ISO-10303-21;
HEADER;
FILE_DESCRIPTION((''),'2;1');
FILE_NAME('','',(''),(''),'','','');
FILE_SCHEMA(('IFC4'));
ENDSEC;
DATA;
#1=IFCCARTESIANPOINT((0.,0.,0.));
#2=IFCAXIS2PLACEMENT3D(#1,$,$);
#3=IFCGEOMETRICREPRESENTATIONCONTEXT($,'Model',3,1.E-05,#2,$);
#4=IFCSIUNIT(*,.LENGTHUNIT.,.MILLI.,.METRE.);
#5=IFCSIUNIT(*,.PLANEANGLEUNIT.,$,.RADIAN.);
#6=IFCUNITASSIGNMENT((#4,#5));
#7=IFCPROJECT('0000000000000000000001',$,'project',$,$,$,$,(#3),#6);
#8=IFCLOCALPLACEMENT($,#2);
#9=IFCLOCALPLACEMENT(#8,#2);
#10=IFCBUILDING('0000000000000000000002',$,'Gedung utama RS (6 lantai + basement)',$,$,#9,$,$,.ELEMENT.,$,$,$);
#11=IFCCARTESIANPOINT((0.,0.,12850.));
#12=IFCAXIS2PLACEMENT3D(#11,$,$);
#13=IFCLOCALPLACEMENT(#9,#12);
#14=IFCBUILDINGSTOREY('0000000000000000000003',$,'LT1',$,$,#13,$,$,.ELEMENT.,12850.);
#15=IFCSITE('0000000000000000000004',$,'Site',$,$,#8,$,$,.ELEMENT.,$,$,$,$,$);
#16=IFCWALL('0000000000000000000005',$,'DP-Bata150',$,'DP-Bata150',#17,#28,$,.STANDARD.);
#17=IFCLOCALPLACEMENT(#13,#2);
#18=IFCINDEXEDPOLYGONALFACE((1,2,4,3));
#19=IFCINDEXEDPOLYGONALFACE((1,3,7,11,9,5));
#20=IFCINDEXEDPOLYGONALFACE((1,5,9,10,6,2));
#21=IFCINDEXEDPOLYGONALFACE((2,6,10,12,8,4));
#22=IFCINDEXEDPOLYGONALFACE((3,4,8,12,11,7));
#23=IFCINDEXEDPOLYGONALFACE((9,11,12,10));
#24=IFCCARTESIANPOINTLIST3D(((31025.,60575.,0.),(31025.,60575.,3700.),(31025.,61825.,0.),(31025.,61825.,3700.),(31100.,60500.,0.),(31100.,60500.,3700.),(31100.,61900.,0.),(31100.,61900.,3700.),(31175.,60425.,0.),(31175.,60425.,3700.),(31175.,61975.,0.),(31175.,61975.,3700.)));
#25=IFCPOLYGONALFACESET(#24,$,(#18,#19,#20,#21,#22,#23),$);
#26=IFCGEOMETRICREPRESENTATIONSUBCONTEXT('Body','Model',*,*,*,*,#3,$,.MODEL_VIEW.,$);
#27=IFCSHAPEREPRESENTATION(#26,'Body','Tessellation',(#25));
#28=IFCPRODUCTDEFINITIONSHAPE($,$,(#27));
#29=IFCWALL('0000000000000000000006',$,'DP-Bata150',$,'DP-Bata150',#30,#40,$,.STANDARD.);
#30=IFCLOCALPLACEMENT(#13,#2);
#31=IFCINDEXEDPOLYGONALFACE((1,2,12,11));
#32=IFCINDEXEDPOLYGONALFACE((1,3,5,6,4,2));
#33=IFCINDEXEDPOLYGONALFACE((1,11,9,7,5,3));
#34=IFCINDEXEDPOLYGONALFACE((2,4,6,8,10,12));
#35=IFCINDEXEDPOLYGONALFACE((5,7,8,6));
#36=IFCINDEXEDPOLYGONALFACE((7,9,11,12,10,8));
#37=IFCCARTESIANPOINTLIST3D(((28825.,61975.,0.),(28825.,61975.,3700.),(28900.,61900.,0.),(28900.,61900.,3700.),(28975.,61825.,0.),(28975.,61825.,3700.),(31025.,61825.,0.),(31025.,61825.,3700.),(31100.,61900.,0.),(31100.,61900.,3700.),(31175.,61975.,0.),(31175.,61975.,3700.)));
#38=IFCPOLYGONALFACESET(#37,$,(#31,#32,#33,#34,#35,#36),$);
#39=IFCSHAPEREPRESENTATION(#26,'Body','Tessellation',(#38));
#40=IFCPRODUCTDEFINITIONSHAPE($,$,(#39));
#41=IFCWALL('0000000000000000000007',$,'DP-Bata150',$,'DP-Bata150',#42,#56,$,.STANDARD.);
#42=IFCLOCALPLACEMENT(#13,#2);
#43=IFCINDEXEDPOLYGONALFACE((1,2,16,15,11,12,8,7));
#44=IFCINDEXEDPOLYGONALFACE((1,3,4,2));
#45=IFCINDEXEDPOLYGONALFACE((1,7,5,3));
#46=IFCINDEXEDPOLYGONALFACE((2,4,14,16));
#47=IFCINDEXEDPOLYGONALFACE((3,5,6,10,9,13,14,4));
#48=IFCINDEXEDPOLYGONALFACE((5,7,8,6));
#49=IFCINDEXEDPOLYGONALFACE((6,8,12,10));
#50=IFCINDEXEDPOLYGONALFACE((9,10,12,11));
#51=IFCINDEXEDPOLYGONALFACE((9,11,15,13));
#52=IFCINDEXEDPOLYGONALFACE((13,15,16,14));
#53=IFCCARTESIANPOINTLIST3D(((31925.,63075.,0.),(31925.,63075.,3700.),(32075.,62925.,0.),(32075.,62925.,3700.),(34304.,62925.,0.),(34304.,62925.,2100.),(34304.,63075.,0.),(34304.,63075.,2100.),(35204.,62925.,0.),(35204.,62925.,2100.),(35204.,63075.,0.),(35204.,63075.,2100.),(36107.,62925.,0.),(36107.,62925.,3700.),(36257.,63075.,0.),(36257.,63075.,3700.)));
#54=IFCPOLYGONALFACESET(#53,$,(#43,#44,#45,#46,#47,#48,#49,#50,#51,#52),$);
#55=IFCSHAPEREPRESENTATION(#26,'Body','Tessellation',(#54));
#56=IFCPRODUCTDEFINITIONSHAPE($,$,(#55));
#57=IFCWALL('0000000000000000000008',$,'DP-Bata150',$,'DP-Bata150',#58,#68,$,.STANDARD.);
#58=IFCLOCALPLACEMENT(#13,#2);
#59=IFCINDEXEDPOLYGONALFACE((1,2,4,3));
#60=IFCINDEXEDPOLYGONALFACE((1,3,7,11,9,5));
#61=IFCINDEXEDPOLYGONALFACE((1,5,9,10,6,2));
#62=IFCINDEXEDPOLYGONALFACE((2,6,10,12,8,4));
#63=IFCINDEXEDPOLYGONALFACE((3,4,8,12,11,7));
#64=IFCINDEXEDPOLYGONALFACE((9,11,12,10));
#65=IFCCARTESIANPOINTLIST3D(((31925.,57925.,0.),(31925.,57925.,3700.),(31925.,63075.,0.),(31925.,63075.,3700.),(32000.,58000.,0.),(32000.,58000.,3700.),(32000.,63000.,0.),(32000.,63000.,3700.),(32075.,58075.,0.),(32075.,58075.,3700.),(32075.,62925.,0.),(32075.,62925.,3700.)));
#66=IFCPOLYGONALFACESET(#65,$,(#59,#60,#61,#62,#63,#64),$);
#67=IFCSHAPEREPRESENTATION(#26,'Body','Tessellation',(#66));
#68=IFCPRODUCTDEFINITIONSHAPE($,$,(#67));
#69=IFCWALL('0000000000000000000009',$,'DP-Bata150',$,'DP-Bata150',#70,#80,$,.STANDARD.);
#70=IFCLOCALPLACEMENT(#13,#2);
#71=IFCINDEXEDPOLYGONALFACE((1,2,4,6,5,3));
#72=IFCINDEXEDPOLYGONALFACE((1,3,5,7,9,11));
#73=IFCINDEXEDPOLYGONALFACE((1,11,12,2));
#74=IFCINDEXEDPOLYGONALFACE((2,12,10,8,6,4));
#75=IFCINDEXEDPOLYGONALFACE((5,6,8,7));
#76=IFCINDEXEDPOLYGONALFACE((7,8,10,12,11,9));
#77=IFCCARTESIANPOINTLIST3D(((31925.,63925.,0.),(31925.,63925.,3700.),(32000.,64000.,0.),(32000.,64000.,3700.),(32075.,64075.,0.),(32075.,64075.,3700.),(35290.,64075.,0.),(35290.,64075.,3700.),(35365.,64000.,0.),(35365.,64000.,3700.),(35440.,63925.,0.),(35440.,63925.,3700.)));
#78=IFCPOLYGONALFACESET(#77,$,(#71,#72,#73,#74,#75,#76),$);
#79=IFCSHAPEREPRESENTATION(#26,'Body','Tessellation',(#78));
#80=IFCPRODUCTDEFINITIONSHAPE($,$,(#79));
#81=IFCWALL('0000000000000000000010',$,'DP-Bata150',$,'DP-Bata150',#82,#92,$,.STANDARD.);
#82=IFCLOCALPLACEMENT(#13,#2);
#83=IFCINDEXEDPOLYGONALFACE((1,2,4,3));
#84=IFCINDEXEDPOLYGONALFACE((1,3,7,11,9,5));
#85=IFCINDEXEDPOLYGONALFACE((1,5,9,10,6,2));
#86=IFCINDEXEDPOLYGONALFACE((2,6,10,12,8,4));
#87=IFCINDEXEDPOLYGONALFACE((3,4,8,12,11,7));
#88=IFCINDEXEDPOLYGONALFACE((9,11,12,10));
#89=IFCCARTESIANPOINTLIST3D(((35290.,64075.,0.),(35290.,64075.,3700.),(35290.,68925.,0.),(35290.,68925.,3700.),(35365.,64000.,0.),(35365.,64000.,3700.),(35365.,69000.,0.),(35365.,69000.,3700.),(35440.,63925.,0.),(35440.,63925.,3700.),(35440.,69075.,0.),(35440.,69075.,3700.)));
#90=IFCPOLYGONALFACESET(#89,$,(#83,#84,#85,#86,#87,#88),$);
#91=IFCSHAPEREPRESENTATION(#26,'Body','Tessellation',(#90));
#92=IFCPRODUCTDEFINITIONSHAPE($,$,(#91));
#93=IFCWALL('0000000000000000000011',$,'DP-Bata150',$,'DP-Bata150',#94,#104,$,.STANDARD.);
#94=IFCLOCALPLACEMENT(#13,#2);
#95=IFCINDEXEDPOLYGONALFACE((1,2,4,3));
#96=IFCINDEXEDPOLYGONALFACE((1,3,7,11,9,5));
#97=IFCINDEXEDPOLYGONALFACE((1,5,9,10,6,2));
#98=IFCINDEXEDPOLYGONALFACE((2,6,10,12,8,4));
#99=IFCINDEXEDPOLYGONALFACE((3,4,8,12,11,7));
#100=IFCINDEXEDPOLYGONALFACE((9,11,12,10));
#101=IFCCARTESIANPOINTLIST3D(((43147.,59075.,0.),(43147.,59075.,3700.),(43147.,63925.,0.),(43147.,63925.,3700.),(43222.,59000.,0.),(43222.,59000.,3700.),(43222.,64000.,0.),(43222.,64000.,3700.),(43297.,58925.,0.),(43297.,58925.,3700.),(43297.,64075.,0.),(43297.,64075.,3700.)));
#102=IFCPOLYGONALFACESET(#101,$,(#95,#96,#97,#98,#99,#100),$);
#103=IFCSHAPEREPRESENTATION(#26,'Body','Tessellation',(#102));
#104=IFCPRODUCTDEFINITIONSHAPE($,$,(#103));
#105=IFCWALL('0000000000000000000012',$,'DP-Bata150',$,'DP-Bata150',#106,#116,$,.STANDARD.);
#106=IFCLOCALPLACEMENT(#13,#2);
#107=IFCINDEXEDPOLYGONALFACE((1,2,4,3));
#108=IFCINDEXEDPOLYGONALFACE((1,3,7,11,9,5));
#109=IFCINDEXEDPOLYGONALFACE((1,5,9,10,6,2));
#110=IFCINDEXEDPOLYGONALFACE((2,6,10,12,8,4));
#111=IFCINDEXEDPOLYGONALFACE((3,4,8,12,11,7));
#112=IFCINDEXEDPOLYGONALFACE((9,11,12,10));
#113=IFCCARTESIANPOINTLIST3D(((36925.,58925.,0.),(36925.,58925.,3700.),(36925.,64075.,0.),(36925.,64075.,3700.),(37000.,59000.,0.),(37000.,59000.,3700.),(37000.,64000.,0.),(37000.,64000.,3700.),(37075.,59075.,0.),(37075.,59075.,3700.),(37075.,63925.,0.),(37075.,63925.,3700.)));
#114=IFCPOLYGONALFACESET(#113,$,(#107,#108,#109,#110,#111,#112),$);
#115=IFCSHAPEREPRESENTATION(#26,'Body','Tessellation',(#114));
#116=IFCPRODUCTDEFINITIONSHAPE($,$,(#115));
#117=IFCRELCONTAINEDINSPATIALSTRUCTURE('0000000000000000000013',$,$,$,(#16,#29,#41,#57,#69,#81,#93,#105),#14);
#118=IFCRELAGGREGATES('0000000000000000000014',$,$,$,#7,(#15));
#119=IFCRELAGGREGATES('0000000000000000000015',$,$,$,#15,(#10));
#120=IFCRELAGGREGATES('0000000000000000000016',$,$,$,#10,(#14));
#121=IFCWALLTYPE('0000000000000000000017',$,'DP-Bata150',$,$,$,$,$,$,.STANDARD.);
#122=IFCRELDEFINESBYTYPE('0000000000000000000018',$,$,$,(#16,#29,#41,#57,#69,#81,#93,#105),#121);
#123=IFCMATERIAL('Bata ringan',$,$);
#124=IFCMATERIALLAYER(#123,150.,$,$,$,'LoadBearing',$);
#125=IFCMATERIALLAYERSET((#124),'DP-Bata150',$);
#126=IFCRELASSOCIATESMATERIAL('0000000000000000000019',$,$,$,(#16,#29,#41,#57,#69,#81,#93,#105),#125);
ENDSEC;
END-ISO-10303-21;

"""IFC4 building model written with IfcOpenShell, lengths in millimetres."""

from ifc_helpers import new_model, si_unit, frame, frame_2d, origin, place, context, subcontext, project, spatial, polyline, rectangle, outline, extrude, material, layer, layer_set, layer_usage, type_object, element, save


model = new_model("IFC4")

# Units and contexts
model_context = context("Model", 3, precision=1e-05, world=origin())
body_context = subcontext(model_context, "Body", "Model", "MODEL_VIEW")
ifc_project = project(units=[si_unit("LENGTHUNIT", "METRE", prefix="MILLI"), si_unit("PLANEANGLEUNIT", "RADIAN")], contexts=[model_context])

# Site, building, storey
site_placement = place(None, origin())
site = spatial("IfcSite", under=ifc_project, at=site_placement, Name="Site", CompositionType="ELEMENT")
building_placement = place(site_placement, origin())
building = spatial("IfcBuilding", under=site, at=building_placement, Name="Gedung utama RS (6 lantai + basement)", CompositionType="ELEMENT")
storey_placement = place(building_placement, frame((0.0, 0.0, 12850.0)))
storey = spatial("IfcBuildingStorey", under=building, at=storey_placement, Name="LT1", CompositionType="ELEMENT", Elevation=12850.0)

# Shared definitions
ifc_material = material(Name="Bata ringan")

# Shared definitions
ifc_layer_1 = layer(ifc_material, 150.0, Category="LoadBearing")
ifc_layer_set_1 = layer_set([ifc_layer_1], Name="DP-Bata150")
ifc_layer_usage_1 = layer_usage(ifc_layer_set_1, "AXIS2", "NEGATIVE", 75.0)
wall_type_1 = type_object("IfcWallType", Name="DP-Bata150", PredefinedType="STANDARD")

# Walls
wall_1_placement = place(storey_placement, frame((31100.0, 60500.0, 0.0), z_axis=(0.0, 0.0, 1.0), x_axis=(0.0, 1.0, 0.0)))
element("IfcWall", 1, at=wall_1_placement, inside=storey, type_object=wall_type_1, material=ifc_layer_usage_1, Name="DP-Bata150", ObjectType="DP-Bata150", PredefinedType="STANDARD", context=body_context, shape_type="SweptSolid", body=[
    extrude(outline(polyline([(-75.0, -75.0), (0.0, 0.0), (75.0, 75.0), (1325.0, 75.0), (1400.0, 0.0), (1475.0, -75.0), (-75.0, -75.0)])), origin(), (0.0, 0.0, 1.0), 3700.0),
])
wall_2_placement = place(storey_placement, frame((31100.0, 61900.0, 0.0), z_axis=(0.0, 0.0, 1.0), x_axis=(-1.0, 0.0, 0.0)))
element("IfcWall", 2, at=wall_2_placement, inside=storey, type_object=wall_type_1, material=ifc_layer_usage_1, Name="DP-Bata150", ObjectType="DP-Bata150", PredefinedType="STANDARD", context=body_context, shape_type="SweptSolid", body=[
    extrude(outline(polyline([(-75.0, -75.0), (0.0, 0.0), (75.0, 75.0), (2125.0, 75.0), (2200.0, 0.0), (2275.0, -75.0), (-75.0, -75.0)])), origin(), (0.0, 0.0, 1.0), 3700.0),
])

# Wall, opening
wall_3_placement = place(storey_placement, frame((36182.0, 63000.0, 0.0), z_axis=(0.0, 0.0, 1.0), x_axis=(-1.0, 0.0, 0.0)))
wall_3 = element("IfcWall", 3, at=wall_3_placement, inside=storey, type_object=wall_type_1, material=ifc_layer_usage_1, Name="DP-Bata150", ObjectType="DP-Bata150", PredefinedType="STANDARD", context=body_context, shape_type="SweptSolid", body=[
    extrude(outline(polyline([(-75.0, -75.0), (0.0, 0.0), (75.0, 75.0), (4107.0, 75.0), (4182.0, 0.0), (4257.0, -75.0), (-75.0, -75.0)])), origin(), (0.0, 0.0, 1.0), 3700.0),
])
opening_1_placement = place(wall_3_placement, frame((978.0, 0.0, 0.0), z_axis=(0.0, 0.0, 1.0), x_axis=(1.0, 0.0, 0.0)))
element("IfcOpeningElement", 4, at=opening_1_placement, cuts=wall_3, PredefinedType="OPENING", context=body_context, shape_type="SweptSolid", body=[
    extrude(rectangle(XDim=900.0, YDim=170.0, at=frame_2d((450.0, 0.0))), origin(), (0.0, 0.0, 1.0), 2100.0),
])

# Walls
wall_4_placement = place(storey_placement, frame((32000.0, 63000.0, 0.0), z_axis=(0.0, 0.0, 1.0), x_axis=(0.0, -1.0, 0.0)))
element("IfcWall", 5, at=wall_4_placement, inside=storey, type_object=wall_type_1, material=ifc_layer_usage_1, Name="DP-Bata150", ObjectType="DP-Bata150", PredefinedType="STANDARD", context=body_context, shape_type="SweptSolid", body=[
    extrude(outline(polyline([(-75.0, -75.0), (0.0, 0.0), (75.0, 75.0), (4925.0, 75.0), (5000.0, 0.0), (5075.0, -75.0), (-75.0, -75.0)])), origin(), (0.0, 0.0, 1.0), 3700.0),
])
wall_5_placement = place(storey_placement, frame((32000.0, 64000.0, 0.0), z_axis=(0.0, 0.0, 1.0), x_axis=(1.0, 0.0, 0.0)))
element("IfcWall", 6, at=wall_5_placement, inside=storey, type_object=wall_type_1, material=ifc_layer_usage_1, Name="DP-Bata150", ObjectType="DP-Bata150", PredefinedType="STANDARD", context=body_context, shape_type="SweptSolid", body=[
    extrude(outline(polyline([(-75.0, -75.0), (0.0, 0.0), (75.0, 75.0), (3290.0, 75.0), (3365.0, 0.0), (3440.0, -75.0), (-75.0, -75.0)])), origin(), (0.0, 0.0, 1.0), 3700.0),
])
for number, where, z_axis, x_axis, name in (
    (7, (35365.0, 64000.0, 0.0), (0.0, 0.0, 1.0), (0.0, 1.0, 0.0), "DP-Bata150"),
    (8, (43222.0, 59000.0, 0.0), (0.0, 0.0, 1.0), (0.0, 1.0, 0.0), "DP-Bata150"),
    (9, (37000.0, 64000.0, 0.0), (0.0, 0.0, 1.0), (0.0, -1.0, 0.0), "DP-Bata150"),
):
    element("IfcWall", number, at=place(storey_placement, frame(where, z_axis=z_axis, x_axis=x_axis)), inside=storey, type_object=wall_type_1, material=ifc_layer_usage_1, Name=name, ObjectType="DP-Bata150", PredefinedType="STANDARD", context=body_context, shape_type="SweptSolid", body=[
        extrude(outline(polyline([(-75.0, -75.0), (0.0, 0.0), (75.0, 75.0), (4925.0, 75.0), (5000.0, 0.0), (5075.0, -75.0), (-75.0, -75.0)])), origin(), (0.0, 0.0, 1.0), 3700.0),
    ])

save(model, "model.ifc")
